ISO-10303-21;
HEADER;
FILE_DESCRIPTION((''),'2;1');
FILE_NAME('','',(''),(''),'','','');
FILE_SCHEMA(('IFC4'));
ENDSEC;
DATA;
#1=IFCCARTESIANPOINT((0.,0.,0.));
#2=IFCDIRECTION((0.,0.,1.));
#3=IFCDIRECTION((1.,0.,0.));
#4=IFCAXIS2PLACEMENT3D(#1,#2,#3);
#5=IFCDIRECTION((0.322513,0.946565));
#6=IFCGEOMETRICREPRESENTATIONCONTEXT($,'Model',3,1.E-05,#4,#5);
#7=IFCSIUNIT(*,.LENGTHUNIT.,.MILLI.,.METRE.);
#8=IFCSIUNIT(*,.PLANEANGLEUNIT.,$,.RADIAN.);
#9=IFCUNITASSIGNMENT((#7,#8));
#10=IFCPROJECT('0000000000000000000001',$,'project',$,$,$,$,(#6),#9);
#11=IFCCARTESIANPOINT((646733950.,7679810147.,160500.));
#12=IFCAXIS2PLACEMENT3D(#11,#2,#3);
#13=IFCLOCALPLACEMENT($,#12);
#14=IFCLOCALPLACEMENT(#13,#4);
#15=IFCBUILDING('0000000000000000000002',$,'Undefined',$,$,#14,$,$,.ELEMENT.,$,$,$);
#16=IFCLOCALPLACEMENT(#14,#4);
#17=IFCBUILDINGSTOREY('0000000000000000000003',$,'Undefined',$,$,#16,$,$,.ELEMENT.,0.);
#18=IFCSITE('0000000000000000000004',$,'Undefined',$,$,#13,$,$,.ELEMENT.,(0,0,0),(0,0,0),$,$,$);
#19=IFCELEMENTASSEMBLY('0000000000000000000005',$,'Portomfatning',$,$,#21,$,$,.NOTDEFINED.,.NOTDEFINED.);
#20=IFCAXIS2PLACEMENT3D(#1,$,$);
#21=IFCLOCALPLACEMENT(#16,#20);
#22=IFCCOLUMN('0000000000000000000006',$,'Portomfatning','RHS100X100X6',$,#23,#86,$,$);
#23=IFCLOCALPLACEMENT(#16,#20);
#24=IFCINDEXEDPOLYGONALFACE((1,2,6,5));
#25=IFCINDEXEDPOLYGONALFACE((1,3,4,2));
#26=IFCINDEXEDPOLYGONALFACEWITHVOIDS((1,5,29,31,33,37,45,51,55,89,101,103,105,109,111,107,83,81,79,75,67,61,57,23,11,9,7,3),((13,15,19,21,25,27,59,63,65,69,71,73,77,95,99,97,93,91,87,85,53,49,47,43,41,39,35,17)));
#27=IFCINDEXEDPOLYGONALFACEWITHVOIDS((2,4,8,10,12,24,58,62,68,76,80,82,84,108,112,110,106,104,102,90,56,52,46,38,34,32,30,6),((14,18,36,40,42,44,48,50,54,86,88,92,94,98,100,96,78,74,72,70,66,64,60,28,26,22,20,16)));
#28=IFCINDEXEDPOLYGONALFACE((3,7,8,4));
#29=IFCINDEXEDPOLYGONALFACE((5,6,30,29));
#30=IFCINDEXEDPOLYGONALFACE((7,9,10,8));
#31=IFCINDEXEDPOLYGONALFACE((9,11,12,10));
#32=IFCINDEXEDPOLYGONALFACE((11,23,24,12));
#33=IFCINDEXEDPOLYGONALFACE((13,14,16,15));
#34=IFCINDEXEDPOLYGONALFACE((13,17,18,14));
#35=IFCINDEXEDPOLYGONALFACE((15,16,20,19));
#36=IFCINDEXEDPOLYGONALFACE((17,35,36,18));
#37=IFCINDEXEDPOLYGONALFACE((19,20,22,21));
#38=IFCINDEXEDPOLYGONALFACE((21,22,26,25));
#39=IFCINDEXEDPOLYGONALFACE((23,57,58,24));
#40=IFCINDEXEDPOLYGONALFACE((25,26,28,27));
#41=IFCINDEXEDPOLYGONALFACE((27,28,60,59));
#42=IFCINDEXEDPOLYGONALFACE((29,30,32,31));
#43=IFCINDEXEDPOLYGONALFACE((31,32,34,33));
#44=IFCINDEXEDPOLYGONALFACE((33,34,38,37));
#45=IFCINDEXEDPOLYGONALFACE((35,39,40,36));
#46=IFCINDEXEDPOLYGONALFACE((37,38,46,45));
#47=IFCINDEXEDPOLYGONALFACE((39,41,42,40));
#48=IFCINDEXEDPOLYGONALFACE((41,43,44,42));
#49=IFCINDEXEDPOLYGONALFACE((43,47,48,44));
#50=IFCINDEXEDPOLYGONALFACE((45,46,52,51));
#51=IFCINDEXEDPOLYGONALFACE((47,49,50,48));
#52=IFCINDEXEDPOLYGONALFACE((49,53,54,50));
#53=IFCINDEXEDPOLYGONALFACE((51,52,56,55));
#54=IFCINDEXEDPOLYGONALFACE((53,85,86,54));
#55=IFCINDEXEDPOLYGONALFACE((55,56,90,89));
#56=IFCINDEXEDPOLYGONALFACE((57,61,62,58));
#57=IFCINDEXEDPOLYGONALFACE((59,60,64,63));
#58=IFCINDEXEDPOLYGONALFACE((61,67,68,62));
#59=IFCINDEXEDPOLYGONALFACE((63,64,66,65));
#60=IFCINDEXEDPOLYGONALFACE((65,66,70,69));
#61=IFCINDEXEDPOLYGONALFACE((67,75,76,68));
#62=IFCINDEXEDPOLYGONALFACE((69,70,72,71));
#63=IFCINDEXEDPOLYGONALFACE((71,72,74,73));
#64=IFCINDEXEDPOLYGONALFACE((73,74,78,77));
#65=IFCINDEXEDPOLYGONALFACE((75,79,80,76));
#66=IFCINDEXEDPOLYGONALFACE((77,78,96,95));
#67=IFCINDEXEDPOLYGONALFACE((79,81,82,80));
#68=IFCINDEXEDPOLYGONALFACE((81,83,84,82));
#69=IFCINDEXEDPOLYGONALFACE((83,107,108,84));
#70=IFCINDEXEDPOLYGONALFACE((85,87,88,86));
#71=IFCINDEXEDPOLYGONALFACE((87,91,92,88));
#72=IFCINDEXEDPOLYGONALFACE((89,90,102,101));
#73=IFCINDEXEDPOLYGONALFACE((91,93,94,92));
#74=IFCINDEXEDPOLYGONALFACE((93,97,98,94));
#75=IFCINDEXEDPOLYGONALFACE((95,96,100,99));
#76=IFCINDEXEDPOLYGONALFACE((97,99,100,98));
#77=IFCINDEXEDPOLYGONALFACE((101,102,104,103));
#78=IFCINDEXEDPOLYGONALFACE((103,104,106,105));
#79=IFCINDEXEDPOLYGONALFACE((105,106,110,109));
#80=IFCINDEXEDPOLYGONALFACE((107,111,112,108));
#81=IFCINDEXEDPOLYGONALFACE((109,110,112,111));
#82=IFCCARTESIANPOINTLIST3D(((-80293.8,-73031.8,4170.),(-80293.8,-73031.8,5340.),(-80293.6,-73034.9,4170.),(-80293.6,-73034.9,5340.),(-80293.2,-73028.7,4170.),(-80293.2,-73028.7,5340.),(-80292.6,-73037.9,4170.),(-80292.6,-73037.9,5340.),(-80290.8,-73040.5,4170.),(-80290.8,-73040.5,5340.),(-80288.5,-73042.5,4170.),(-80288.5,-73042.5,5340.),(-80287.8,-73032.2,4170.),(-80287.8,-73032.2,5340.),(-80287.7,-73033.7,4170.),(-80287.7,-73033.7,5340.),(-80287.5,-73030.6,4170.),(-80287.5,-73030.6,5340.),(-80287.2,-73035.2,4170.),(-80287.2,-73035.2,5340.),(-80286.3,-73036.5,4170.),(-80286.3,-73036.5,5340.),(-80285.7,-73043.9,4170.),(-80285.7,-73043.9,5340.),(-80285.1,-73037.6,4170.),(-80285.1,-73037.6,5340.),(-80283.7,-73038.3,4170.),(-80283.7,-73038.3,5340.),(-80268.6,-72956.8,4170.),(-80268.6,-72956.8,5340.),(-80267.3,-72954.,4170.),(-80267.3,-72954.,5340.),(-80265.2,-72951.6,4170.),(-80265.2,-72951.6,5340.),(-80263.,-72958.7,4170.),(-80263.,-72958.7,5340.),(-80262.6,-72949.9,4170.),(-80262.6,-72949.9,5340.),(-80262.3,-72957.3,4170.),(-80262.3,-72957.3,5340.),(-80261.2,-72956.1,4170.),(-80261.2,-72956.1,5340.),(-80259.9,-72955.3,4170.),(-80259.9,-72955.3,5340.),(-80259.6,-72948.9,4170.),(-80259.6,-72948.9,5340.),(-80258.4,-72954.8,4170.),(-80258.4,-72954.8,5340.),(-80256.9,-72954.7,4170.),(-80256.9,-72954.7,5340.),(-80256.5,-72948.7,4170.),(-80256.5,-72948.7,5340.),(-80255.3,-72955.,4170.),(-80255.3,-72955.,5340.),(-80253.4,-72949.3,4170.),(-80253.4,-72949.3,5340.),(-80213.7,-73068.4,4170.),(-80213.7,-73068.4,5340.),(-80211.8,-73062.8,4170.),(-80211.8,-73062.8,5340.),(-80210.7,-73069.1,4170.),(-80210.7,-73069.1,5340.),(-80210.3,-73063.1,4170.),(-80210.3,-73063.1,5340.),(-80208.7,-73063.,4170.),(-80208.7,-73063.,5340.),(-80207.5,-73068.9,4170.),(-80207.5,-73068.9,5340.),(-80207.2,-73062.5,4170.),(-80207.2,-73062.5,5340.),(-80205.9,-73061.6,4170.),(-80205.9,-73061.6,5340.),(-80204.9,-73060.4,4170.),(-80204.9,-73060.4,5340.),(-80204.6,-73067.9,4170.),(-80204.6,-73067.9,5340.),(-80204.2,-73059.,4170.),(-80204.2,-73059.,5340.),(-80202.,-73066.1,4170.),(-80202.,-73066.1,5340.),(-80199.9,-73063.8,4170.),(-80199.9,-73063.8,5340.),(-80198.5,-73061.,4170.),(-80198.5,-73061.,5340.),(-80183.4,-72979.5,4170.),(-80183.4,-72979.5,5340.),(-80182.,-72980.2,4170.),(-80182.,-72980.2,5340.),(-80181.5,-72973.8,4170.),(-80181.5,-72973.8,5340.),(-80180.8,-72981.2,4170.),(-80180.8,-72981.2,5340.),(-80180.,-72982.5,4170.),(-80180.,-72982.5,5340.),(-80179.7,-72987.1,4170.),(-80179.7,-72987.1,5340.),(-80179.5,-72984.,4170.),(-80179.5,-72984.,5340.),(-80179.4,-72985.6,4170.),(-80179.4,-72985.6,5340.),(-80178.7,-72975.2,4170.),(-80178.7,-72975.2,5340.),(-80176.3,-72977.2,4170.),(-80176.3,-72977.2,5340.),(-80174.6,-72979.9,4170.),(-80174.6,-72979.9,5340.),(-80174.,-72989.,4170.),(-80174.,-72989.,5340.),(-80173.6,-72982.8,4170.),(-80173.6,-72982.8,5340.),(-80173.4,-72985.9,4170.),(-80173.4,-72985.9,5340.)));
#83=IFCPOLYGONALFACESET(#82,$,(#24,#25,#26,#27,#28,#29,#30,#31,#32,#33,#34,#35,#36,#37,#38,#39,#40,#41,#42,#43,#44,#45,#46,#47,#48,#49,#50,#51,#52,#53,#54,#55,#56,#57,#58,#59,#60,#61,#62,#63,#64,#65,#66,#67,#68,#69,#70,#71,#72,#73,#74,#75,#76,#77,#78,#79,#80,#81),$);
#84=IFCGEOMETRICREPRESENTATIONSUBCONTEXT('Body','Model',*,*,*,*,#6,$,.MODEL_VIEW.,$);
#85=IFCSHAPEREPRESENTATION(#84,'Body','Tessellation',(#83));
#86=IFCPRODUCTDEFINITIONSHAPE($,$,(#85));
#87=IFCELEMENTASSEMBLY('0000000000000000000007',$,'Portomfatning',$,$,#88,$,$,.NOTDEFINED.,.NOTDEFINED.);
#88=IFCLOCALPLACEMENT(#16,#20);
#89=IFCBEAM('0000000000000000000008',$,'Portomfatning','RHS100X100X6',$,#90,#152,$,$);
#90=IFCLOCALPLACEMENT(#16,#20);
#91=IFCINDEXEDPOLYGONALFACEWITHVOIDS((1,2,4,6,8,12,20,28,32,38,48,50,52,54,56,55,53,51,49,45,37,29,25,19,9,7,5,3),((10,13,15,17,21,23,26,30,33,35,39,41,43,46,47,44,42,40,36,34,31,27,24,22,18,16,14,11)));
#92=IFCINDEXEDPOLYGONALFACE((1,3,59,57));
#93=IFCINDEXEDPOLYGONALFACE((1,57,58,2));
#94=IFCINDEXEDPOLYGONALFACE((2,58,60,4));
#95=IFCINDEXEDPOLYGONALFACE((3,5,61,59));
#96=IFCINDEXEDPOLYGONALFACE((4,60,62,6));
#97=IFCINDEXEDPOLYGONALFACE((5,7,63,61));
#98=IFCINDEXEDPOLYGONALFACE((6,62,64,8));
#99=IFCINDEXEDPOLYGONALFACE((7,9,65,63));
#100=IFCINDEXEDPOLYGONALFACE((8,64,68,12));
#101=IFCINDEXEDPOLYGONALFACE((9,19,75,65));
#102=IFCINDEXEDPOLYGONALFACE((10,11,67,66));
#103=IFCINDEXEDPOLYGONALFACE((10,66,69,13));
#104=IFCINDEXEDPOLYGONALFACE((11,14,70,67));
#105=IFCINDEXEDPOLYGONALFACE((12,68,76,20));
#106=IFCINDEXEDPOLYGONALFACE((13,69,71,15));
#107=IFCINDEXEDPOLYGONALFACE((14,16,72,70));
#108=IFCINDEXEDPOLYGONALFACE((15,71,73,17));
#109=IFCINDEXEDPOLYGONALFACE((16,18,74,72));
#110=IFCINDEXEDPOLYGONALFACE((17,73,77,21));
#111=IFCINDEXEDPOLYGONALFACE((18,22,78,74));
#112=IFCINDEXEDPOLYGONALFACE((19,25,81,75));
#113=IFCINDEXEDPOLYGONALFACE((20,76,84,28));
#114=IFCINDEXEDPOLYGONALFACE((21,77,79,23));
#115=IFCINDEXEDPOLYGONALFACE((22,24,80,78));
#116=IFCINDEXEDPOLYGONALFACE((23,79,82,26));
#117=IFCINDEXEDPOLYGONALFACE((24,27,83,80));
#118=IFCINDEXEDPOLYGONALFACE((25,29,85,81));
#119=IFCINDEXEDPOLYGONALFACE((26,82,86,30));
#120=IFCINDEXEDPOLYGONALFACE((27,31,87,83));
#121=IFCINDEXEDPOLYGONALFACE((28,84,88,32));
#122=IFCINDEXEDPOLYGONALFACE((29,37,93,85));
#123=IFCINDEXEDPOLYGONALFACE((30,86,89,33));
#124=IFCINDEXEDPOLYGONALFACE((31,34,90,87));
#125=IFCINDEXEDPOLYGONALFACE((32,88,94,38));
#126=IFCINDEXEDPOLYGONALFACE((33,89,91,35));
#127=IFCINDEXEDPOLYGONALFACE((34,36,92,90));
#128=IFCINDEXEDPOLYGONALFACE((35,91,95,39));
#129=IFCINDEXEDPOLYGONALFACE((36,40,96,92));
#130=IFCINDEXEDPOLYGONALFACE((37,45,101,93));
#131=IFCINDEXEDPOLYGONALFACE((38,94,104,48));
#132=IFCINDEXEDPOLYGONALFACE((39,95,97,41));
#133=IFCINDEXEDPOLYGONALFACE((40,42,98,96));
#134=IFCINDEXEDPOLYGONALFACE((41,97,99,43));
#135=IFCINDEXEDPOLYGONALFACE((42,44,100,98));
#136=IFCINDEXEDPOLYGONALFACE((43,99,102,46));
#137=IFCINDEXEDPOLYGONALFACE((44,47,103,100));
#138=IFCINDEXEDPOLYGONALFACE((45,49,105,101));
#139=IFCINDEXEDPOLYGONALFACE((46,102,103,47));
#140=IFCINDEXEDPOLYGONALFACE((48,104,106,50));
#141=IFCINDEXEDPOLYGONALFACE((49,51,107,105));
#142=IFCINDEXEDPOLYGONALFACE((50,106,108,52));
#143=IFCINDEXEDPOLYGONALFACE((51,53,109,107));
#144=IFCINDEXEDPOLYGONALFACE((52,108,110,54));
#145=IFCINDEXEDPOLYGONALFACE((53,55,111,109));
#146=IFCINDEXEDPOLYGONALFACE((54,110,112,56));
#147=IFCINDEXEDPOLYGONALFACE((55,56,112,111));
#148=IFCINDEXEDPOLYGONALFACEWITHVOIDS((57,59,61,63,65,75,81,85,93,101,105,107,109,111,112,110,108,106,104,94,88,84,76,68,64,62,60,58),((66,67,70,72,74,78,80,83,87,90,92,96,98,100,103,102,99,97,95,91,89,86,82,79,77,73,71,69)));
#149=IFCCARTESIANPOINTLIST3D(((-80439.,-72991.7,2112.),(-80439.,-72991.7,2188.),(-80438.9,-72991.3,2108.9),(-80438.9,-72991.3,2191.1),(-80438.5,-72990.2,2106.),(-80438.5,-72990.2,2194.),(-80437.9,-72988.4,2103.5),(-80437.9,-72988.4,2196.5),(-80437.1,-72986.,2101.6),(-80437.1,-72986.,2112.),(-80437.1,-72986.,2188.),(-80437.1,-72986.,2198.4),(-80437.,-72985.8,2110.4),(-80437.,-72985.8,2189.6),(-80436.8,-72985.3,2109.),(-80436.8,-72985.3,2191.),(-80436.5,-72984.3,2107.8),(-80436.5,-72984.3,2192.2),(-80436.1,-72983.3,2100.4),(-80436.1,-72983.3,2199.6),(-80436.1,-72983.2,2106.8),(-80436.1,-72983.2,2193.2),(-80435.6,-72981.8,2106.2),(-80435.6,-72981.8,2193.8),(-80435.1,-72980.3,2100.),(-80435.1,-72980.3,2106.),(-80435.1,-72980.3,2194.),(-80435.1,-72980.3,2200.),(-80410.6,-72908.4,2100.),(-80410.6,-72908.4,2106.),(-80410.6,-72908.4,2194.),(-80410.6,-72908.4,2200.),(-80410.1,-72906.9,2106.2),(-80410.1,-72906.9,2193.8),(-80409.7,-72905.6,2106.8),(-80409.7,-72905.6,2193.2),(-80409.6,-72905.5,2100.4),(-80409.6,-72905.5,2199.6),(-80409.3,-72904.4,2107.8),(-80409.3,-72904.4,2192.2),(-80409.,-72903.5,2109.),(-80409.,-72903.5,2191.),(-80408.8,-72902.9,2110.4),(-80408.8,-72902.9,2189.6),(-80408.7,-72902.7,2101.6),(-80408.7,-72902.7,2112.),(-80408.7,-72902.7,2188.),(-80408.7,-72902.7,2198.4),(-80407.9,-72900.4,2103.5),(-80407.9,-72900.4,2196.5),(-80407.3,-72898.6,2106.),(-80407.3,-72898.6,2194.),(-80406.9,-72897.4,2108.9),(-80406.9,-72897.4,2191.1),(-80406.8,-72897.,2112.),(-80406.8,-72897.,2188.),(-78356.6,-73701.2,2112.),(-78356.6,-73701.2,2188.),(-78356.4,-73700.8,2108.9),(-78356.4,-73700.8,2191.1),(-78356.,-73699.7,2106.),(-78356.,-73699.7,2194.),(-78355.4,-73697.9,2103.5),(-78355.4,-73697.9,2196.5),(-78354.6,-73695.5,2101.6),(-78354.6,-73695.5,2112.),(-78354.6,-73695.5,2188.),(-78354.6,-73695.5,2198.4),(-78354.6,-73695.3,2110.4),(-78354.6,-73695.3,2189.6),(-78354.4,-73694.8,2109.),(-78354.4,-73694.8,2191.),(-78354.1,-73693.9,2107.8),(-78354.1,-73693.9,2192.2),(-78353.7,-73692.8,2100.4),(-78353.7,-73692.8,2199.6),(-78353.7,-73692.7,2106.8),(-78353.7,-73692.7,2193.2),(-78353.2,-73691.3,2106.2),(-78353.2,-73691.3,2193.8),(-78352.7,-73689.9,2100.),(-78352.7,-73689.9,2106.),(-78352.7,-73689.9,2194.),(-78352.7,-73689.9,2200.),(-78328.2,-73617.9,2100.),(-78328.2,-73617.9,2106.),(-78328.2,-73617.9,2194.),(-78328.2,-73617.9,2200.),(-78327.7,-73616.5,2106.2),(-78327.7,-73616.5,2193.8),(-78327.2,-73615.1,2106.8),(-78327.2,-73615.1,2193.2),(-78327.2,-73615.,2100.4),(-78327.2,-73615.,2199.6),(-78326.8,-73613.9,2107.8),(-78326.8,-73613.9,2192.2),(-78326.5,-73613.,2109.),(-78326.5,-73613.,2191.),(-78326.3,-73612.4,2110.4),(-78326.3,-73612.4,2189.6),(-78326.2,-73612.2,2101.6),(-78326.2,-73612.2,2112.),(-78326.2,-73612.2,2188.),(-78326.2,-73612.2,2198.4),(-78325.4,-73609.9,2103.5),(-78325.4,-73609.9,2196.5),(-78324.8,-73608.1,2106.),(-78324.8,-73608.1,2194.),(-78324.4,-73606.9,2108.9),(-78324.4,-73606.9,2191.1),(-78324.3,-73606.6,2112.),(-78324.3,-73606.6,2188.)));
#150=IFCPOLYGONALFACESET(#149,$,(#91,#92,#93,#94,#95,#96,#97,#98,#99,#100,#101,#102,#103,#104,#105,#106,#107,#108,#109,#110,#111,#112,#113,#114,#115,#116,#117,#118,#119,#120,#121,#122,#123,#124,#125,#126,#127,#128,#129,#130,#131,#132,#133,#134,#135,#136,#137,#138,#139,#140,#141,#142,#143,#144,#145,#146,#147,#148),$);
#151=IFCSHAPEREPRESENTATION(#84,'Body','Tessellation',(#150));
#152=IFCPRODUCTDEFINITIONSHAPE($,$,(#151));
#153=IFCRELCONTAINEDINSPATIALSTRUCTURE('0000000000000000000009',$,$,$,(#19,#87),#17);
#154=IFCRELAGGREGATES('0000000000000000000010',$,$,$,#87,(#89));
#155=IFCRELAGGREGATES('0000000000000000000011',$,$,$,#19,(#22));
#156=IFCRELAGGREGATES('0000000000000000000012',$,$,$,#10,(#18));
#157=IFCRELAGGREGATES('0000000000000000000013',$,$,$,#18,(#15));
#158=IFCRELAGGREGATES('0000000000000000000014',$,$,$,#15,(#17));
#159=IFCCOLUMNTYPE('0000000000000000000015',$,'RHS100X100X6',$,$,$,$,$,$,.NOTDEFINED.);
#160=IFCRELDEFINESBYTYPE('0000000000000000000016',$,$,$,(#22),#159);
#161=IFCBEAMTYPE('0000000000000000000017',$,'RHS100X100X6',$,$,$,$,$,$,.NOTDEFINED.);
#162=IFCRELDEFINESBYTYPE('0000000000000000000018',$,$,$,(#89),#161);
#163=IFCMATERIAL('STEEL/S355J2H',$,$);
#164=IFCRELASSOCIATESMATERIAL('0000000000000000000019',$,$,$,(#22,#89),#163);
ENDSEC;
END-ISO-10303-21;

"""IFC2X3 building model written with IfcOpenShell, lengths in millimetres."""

from ifc_helpers import new_model, si_unit, direction, frame, origin_with_axes, origin_2d_with_axis, place, context, subcontext, project, spatial, hollow_rectangle, extrude, clip, halfspace, material, type_object, element, aggregate, save


model = new_model("IFC2X3")

# Units and contexts
model_context = context("Model", 3, precision=1e-05, world=origin_with_axes(), true_north=direction((0.322513, 0.946565)))
body_context = subcontext(model_context, "Body", "Model", "MODEL_VIEW")
ifc_project = project(units=[si_unit("LENGTHUNIT", "METRE", prefix="MILLI"), si_unit("PLANEANGLEUNIT", "RADIAN")], contexts=[model_context])

# Site, building, storey
site_placement = place(None, frame((646733950.0, 7679810147.0, 160500.0), z_axis=(0.0, 0.0, 1.0), x_axis=(1.0, 0.0, 0.0)))
site = spatial("IfcSite", under=ifc_project, at=site_placement, Name="Undefined", CompositionType="ELEMENT", RefLatitude=(0, 0, 0), RefLongitude=(0, 0, 0))
building_placement = place(site_placement, origin_with_axes())
building = spatial("IfcBuilding", under=site, at=building_placement, Name="Undefined", CompositionType="ELEMENT")
storey_placement = place(building_placement, origin_with_axes())
storey = spatial("IfcBuildingStorey", under=building, at=storey_placement, Name="Undefined", CompositionType="ELEMENT", Elevation=0.0)

# Element assembly, column
ifc_material_1 = material(Name="STEEL/S355J2H")
column_type = type_object("IfcColumnType", Name="RHS100X100X6", PredefinedType="NOTDEFINED")
assembly_1_placement = place(storey_placement, origin_with_axes())
assembly_1 = element("IfcElementAssembly", 1, at=assembly_1_placement, inside=storey, Name="Portomfatning", AssemblyPlace="NOTDEFINED", PredefinedType="NOTDEFINED")
column_1_placement = place(assembly_1_placement, frame((-80233.6, -73008.9, 4160.0), z_axis=(0.0, 0.0, 1.0), x_axis=(-0.322513, -0.946565, 0.0)))
column_1 = element("IfcColumn", 2, at=column_1_placement, type_object=column_type, material=ifc_material_1, Name="Portomfatning", Description="RHS100X100X6", context=body_context, shape_type="Clipping", body=[
    clip(clip(extrude(hollow_rectangle(XDim=100.0, YDim=100.0, WallThickness=6.0, InnerFilletRadius=6.0, OuterFilletRadius=12.0, at=origin_2d_with_axis()), frame((0.0, 0.0, 1190.0), z_axis=(0.0, 0.0, -1.0), x_axis=(0.0, 1.0, 0.0)), (0.0, 0.0, 1.0), 1190.0), halfspace(frame((0.0, 50.0, 1180.0), z_axis=(0.0, 0.0, -1.0), x_axis=(-1.0, 0.0, 0.0)), True)), halfspace(frame((0.0, 50.0, 10.0), z_axis=(0.0, 0.0, 1.0), x_axis=(1.0, 0.0, 0.0)), True)),
])

# Element assembly, beam
assembly_2_placement = place(storey_placement, origin_with_axes())
assembly_2 = element("IfcElementAssembly", 3, at=assembly_2_placement, inside=storey, Name="Portomfatning", AssemblyPlace="NOTDEFINED", PredefinedType="NOTDEFINED")
beam_type_1 = type_object("IfcBeamType", Name="RHS100X100X6", PredefinedType="NOTDEFINED")
beam_1_placement = place(assembly_2_placement, frame((-80431.9, -72941.3, 2150.0), z_axis=(0.322513, 0.946565, 0.0), x_axis=(0.946565, -0.322513, 0.0)))
beam_1 = element("IfcBeam", 4, at=beam_1_placement, type_object=beam_type_1, material=ifc_material_1, Name="Portomfatning", Description="RHS100X100X6", context=body_context, shape_type="Clipping", body=[
    clip(clip(extrude(hollow_rectangle(XDim=100.0, YDim=100.0, WallThickness=6.0, InnerFilletRadius=6.0, OuterFilletRadius=12.0, at=origin_2d_with_axis()), frame((2271.2, 0.0, 0.0), z_axis=(-1.0, 0.0, 0.0), x_axis=(0.0, -1.0, 0.0)), (0.0, 0.0, 1.0), 2323.3), halfspace(frame((2209.6, 50.0, 0.0), z_axis=(-1.0, 0.0, 0.0), x_axis=(0.0, 0.0, 1.0)), True)), halfspace(frame((9.6, 50.0, 0.0), z_axis=(1.0, 0.0, 0.0), x_axis=(0.0, 0.0, -1.0)), True)),
])

aggregate(assembly_2, [beam_1])
aggregate(assembly_1, [column_1])

save(model, "model.ifc")
